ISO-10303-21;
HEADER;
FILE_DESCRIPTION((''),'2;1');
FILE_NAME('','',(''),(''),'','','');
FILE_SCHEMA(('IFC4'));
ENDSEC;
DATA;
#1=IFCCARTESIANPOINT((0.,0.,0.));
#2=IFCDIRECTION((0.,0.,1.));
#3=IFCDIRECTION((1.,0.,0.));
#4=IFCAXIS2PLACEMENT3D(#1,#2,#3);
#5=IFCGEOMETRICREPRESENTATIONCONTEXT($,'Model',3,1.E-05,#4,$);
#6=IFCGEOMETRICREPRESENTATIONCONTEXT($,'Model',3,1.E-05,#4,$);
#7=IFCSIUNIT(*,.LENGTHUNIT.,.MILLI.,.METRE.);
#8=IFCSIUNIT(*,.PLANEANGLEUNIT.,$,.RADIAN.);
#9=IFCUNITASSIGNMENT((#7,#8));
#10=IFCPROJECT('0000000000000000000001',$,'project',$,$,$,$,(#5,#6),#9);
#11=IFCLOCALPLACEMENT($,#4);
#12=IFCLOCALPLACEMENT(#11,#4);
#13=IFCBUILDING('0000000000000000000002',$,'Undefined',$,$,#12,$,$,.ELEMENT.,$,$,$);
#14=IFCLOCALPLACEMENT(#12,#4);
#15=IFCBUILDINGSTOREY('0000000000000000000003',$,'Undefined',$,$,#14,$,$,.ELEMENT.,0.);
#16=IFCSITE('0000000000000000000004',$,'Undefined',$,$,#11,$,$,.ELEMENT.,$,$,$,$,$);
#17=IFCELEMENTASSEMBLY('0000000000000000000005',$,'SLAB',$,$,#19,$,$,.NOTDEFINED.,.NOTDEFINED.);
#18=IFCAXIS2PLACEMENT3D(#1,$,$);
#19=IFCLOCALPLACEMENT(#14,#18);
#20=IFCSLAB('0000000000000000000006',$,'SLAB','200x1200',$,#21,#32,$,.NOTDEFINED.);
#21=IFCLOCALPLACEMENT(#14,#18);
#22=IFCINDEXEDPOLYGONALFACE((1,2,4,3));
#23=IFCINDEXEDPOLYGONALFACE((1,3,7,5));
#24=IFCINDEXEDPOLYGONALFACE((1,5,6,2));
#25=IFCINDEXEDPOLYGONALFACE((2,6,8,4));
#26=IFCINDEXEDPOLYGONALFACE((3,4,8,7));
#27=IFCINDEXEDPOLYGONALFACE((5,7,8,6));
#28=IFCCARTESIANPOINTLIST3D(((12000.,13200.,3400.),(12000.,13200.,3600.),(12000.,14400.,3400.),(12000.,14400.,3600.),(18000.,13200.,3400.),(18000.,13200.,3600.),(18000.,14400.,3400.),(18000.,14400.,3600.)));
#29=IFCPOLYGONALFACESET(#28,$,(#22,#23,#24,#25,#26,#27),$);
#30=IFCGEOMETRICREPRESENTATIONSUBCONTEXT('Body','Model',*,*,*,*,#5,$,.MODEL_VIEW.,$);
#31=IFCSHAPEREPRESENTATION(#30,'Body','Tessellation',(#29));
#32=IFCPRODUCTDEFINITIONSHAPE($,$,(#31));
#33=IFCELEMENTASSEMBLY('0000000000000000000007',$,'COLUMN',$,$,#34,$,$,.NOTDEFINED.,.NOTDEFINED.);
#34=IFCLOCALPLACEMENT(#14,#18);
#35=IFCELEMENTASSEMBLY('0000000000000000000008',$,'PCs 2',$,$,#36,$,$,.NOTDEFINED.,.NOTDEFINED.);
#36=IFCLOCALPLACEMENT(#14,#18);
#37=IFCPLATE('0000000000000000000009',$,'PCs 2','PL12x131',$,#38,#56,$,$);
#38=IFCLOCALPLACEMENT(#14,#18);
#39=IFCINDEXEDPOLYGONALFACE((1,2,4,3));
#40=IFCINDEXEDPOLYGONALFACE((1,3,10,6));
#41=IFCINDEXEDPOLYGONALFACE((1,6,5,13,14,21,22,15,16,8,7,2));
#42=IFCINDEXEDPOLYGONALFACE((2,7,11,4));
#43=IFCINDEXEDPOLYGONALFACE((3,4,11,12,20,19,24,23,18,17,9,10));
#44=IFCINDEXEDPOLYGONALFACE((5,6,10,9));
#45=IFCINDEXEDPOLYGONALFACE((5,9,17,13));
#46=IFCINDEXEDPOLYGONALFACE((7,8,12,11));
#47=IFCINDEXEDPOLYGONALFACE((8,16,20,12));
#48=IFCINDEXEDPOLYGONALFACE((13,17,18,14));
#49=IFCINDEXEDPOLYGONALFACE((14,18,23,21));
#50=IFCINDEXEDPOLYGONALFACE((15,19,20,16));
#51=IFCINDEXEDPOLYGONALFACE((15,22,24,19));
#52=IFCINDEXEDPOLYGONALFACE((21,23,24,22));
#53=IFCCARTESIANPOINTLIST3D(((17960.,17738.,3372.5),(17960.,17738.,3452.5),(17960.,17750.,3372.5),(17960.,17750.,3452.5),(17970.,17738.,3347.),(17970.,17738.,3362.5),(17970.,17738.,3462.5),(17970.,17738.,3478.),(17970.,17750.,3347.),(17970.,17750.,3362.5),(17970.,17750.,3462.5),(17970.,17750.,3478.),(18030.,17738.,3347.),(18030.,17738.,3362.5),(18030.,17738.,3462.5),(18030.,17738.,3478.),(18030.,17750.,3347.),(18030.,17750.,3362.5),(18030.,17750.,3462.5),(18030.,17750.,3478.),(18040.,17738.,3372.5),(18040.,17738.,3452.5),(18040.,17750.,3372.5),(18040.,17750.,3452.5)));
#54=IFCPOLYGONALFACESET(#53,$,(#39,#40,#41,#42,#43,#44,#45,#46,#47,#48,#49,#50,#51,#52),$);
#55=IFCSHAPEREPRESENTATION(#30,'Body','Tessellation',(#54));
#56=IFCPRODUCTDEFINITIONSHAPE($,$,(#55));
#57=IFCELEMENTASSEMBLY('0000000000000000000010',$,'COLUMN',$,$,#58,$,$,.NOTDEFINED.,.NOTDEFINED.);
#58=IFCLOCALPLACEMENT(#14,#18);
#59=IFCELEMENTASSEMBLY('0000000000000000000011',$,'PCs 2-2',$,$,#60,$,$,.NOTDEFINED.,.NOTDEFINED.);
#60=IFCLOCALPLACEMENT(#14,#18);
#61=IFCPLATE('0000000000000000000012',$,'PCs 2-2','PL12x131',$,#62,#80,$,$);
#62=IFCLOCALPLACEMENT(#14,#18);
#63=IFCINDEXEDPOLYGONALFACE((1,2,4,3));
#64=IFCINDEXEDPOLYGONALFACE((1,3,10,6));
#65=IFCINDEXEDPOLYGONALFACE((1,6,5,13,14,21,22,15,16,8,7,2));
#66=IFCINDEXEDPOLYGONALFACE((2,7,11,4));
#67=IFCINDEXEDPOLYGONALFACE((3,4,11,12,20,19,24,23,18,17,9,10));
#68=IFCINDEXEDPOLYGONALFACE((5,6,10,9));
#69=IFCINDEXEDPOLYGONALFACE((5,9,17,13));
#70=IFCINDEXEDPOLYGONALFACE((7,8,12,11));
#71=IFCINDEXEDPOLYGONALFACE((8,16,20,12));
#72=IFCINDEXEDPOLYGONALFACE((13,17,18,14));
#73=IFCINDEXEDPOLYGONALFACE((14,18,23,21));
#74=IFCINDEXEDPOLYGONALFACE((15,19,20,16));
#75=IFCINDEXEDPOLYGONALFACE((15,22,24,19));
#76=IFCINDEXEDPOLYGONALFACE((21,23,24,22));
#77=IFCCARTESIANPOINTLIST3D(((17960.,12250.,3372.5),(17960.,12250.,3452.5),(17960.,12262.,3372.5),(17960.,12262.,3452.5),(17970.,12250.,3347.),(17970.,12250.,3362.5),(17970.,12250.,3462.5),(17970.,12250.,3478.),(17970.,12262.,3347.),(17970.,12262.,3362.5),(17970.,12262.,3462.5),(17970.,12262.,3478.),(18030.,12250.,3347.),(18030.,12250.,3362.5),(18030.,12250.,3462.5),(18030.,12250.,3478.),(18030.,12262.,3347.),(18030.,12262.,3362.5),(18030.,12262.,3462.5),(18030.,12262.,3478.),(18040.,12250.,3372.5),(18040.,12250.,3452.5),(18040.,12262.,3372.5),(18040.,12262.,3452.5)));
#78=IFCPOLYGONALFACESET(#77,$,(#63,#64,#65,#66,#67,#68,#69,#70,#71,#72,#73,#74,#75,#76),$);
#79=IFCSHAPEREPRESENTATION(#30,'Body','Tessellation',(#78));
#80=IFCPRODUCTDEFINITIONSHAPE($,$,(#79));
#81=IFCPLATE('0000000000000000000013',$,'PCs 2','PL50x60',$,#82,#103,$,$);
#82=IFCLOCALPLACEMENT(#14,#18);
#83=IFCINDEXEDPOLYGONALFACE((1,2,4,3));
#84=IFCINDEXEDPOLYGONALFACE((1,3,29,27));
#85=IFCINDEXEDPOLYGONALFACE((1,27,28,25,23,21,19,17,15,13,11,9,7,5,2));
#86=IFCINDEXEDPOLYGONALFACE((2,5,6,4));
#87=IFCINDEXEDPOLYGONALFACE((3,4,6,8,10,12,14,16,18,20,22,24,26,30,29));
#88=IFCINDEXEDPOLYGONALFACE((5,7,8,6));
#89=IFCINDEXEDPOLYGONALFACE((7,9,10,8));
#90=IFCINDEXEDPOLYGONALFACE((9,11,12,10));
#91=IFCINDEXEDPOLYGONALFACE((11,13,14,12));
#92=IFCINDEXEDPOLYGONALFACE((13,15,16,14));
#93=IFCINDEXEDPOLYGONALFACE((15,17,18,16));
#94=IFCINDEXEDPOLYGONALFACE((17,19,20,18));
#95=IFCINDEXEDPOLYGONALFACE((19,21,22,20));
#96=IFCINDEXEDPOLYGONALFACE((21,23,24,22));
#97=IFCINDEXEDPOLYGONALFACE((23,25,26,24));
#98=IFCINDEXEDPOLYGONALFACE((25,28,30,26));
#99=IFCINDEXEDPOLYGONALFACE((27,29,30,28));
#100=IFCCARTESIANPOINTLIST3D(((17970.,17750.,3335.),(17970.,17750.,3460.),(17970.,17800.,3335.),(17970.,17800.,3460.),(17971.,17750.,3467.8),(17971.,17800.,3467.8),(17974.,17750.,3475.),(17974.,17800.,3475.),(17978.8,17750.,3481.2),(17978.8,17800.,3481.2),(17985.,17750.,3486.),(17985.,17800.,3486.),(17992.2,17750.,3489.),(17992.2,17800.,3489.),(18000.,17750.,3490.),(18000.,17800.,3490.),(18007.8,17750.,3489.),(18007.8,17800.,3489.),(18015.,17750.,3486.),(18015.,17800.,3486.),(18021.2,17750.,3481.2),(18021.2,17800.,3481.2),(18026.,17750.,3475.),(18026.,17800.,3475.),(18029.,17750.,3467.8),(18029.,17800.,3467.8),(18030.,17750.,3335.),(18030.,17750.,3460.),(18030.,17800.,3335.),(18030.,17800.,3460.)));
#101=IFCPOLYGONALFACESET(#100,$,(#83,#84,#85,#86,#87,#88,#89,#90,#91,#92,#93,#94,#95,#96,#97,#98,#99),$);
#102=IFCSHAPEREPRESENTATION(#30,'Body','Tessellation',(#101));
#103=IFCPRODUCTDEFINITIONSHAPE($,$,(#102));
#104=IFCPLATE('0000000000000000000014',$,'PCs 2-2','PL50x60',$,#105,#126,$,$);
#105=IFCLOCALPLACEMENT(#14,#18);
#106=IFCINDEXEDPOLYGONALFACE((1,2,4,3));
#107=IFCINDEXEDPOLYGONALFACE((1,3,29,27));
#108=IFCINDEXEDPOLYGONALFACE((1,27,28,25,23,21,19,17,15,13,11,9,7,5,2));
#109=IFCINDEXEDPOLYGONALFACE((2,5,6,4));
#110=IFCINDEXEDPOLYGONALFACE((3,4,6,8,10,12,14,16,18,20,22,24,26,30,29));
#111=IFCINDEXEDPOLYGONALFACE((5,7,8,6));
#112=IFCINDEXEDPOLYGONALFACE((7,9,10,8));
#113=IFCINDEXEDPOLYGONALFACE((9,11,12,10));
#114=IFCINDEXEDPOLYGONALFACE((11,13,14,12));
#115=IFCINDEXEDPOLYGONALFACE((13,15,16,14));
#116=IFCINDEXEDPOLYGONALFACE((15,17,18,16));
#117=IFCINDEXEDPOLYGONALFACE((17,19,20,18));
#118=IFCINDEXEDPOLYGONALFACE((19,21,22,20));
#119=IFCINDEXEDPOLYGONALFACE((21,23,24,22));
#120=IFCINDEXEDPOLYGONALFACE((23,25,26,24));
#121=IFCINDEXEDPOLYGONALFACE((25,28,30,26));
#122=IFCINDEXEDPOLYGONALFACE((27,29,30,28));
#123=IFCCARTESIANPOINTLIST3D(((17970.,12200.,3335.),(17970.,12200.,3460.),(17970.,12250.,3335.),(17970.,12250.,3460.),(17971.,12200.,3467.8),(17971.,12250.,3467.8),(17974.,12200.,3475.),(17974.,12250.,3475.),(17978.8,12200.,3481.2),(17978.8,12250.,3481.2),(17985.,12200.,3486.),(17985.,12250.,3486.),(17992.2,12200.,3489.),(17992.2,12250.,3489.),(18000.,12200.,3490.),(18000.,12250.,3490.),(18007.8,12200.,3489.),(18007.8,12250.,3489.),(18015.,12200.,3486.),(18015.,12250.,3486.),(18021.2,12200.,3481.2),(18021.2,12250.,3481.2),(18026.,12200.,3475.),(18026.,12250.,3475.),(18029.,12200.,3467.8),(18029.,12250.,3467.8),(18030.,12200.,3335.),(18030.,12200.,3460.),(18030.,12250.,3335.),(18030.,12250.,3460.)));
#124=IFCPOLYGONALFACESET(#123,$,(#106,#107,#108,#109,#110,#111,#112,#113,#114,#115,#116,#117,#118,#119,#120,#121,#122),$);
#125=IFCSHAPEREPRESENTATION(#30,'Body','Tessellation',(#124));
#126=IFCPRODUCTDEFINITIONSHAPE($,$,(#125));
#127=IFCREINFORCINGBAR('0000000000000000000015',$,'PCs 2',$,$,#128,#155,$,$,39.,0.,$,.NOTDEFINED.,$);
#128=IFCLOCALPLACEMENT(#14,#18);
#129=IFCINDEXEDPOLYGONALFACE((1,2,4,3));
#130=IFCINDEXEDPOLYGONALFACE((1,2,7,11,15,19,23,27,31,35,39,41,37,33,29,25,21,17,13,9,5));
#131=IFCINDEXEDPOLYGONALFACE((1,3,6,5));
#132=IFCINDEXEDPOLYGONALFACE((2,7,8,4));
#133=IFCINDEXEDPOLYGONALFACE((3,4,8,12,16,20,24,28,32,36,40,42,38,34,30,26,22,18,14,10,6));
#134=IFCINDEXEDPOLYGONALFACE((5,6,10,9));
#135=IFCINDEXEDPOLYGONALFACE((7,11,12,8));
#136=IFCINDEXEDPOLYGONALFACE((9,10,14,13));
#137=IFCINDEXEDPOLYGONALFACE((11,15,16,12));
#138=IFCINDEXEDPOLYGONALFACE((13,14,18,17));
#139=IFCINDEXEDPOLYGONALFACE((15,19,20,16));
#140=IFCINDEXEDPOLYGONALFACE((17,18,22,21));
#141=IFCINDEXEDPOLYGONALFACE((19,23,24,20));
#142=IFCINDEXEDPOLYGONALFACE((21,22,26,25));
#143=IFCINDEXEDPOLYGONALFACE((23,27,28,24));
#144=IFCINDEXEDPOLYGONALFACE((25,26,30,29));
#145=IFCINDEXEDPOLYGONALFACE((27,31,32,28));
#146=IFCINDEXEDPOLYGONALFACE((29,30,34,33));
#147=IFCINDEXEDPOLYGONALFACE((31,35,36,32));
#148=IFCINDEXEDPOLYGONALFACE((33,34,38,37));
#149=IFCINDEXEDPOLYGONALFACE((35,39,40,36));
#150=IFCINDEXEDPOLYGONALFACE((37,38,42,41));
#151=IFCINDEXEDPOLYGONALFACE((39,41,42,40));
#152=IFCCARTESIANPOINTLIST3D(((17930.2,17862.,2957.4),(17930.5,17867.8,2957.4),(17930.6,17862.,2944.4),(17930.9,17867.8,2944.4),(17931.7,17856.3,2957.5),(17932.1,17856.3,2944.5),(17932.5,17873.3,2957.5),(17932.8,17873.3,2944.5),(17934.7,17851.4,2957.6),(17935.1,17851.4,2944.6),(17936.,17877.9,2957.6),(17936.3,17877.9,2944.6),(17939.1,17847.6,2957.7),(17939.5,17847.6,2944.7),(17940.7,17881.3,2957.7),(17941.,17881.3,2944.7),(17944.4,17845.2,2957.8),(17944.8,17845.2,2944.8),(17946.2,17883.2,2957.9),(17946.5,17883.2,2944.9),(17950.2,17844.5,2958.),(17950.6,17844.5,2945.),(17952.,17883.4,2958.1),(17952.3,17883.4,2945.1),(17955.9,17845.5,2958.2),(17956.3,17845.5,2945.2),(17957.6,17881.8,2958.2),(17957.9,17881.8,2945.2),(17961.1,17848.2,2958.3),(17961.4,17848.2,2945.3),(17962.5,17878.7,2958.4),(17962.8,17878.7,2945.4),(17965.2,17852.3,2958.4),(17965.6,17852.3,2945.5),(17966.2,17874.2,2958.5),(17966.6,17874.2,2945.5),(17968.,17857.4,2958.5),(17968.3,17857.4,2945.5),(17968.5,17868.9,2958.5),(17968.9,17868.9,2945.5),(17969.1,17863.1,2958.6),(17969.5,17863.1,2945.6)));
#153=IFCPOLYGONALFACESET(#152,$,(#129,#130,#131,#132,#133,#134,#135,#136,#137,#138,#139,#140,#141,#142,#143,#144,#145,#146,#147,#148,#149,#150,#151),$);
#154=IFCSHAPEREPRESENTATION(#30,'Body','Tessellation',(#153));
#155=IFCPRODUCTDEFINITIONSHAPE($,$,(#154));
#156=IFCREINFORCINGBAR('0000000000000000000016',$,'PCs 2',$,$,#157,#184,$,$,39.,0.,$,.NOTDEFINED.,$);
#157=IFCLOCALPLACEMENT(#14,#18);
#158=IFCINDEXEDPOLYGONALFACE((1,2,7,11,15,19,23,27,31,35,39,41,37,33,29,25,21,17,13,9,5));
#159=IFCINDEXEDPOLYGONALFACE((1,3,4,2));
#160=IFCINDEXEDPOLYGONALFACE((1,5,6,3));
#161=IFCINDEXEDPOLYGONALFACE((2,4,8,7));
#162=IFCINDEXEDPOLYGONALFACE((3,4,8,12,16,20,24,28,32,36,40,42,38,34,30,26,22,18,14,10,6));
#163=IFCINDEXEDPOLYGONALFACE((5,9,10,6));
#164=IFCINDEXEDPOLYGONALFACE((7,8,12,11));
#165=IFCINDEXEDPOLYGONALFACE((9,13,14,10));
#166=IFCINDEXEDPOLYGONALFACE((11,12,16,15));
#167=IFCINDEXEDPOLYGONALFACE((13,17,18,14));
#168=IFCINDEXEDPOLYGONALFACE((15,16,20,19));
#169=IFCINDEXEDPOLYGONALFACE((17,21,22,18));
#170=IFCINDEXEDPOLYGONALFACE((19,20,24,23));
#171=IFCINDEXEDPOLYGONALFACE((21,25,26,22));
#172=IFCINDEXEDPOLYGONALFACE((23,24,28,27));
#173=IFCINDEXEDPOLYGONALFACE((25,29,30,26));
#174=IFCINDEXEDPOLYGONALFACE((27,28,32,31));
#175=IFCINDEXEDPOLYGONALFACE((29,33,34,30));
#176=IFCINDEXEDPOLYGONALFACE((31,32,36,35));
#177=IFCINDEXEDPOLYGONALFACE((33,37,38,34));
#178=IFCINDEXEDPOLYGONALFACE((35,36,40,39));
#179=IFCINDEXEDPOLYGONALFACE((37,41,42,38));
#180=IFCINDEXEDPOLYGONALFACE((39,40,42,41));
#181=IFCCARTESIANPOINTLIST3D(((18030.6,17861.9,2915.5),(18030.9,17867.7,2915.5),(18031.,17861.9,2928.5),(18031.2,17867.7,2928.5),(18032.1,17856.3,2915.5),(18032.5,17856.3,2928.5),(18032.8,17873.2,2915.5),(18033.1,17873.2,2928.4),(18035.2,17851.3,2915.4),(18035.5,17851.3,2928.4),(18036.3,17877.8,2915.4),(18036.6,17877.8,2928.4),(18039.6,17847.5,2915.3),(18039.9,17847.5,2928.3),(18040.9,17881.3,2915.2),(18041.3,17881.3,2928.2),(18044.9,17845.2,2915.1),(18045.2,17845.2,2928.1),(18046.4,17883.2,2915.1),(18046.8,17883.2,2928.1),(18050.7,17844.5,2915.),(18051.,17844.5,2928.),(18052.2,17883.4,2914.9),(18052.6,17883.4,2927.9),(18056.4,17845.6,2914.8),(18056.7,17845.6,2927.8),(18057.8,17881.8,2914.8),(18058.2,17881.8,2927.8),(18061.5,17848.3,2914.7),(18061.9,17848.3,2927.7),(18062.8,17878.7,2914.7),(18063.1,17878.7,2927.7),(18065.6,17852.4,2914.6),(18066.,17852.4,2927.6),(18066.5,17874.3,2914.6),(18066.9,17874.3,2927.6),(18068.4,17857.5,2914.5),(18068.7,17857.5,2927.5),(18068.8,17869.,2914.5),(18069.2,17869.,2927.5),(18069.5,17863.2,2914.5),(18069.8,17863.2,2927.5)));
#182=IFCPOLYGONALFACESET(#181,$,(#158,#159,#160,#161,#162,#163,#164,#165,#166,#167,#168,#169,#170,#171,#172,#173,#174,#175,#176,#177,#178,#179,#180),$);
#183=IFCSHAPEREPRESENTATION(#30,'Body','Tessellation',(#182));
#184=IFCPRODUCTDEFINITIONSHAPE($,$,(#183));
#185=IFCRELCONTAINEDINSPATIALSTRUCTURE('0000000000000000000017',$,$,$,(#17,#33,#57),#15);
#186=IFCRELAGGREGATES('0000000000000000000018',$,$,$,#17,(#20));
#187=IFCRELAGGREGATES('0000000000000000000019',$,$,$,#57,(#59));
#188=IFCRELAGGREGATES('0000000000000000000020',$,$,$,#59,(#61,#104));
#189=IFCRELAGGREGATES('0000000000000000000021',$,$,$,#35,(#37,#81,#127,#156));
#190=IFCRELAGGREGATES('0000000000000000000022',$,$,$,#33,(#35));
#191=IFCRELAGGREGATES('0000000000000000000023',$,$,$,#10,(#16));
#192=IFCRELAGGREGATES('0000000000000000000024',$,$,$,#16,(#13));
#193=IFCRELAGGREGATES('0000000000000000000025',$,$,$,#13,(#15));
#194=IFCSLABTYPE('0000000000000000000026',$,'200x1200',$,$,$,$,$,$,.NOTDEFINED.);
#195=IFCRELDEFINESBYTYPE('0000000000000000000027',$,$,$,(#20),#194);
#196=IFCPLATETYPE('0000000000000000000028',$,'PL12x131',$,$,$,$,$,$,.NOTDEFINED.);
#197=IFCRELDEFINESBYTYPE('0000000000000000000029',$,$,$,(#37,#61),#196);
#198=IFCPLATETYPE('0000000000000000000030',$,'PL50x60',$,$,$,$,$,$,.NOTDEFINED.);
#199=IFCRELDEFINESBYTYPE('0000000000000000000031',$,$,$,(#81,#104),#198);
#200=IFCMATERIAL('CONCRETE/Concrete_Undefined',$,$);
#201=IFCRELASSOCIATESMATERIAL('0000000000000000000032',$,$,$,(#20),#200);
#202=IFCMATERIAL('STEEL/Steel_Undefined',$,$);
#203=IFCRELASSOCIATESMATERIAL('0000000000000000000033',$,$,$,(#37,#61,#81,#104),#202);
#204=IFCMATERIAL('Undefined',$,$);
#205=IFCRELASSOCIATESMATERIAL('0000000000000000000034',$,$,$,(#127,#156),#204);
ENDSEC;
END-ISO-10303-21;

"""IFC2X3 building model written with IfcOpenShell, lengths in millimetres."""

from ifc_helpers import new_model, entity, si_unit, frame, frame_2d, origin_with_axes, place, context, subcontext, project, spatial, polyline, circle_curve, parameter, trimmed, segment, composite_curve, outline, extrude, source, transform, mapped, material, type_object, element, aggregate, save


model = new_model("IFC2X3")

# Units and contexts
model_context_1 = context("Model", 3, precision=1e-05, world=origin_with_axes())
model_context_2 = context("Model", 3, precision=1e-05, world=origin_with_axes())
body_context = subcontext(model_context_1, "Body", "Model", "MODEL_VIEW")
ifc_project = project(units=[si_unit("LENGTHUNIT", "METRE", prefix="MILLI"), si_unit("PLANEANGLEUNIT", "RADIAN")], contexts=[model_context_1, model_context_2])

# Site, building, storey
site_placement = place(None, origin_with_axes())
site = spatial("IfcSite", under=ifc_project, at=site_placement, Name="Undefined", CompositionType="ELEMENT")
building_placement = place(site_placement, origin_with_axes())
building = spatial("IfcBuilding", under=site, at=building_placement, Name="Undefined", CompositionType="ELEMENT")
storey_placement = place(building_placement, origin_with_axes())
storey = spatial("IfcBuildingStorey", under=building, at=storey_placement, Name="Undefined", CompositionType="ELEMENT", Elevation=0.0)

# Shared definitions
ifc_material_1 = material(Name="STEEL/Steel_Undefined")

# Element assembly, slab
assembly_1_placement = place(storey_placement, origin_with_axes())
assembly_1 = element("IfcElementAssembly", 1, at=assembly_1_placement, inside=storey, Name="SLAB", AssemblyPlace="NOTDEFINED", PredefinedType="NOTDEFINED")
ifc_material_2 = material(Name="CONCRETE/Concrete_Undefined")
slab_type = type_object("IfcSlabType", Name="200x1200", PredefinedType="NOTDEFINED")
slab_placement = place(assembly_1_placement, frame((18000.0, 13200.0, 3500.0), z_axis=(0.0, 0.0, 1.0), x_axis=(0.0, 1.0, 0.0)))
slab = element("IfcSlab", 2, at=slab_placement, type_object=slab_type, material=ifc_material_2, Name="SLAB", Description="200x1200", PredefinedType="NOTDEFINED", context=body_context, shape_type="SweptSolid", body=[
    extrude(outline(polyline([(0.0, 0.0), (1200.0, 0.0), (1200.0, 6000.0), (0.0, 6000.0), (0.0, 0.0)])), frame((0.0, 0.0, -100.0), z_axis=(0.0, 0.0, 1.0), x_axis=(1.0, 0.0, 0.0)), (0.0, 0.0, 1.0), 200.0),
])
aggregate(assembly_1, [slab])

# Element assemblies, plates
assembly_2_placement = place(storey_placement, origin_with_axes())
assembly_2 = element("IfcElementAssembly", 3, at=assembly_2_placement, inside=storey, Name="COLUMN", AssemblyPlace="NOTDEFINED", PredefinedType="NOTDEFINED")
assembly_3_placement = place(assembly_2_placement, origin_with_axes())
assembly_3 = element("IfcElementAssembly", 4, at=assembly_3_placement, Name="PCs 2", AssemblyPlace="NOTDEFINED", PredefinedType="NOTDEFINED")
plate_type_1 = type_object("IfcPlateType", Name="PL12x131", PredefinedType="NOTDEFINED")
plate_1_placement = place(assembly_3_placement, frame((17970.0, 17744.0, 3478.0), z_axis=(0.0, -1.0, 0.0), x_axis=(0.0, 0.0, -1.0)))
plate_1 = element("IfcPlate", 5, at=plate_1_placement, type_object=plate_type_1, material=ifc_material_1, Name="PCs 2", Description="PL12x131", context=body_context, shape_type="SweptSolid", body=[
    extrude(outline(polyline([(0.0, 0.0), (15.5, 0.0), (25.5, -10.0), (105.5, -10.0), (115.5, 0.0), (131.0, 0.0), (131.0, 60.0), (115.5, 60.0), (105.5, 70.0), (25.5, 70.0), (15.5, 60.0), (0.0, 60.0), (0.0, 0.0)])), frame((0.0, 0.0, -6.0), z_axis=(0.0, 0.0, 1.0), x_axis=(1.0, 0.0, 0.0)), (0.0, 0.0, 1.0), 12.0),
])
assembly_4_placement = place(storey_placement, origin_with_axes())
assembly_4 = element("IfcElementAssembly", 6, at=assembly_4_placement, inside=storey, Name="COLUMN", AssemblyPlace="NOTDEFINED", PredefinedType="NOTDEFINED")
assembly_5_placement = place(assembly_4_placement, origin_with_axes())
assembly_5 = element("IfcElementAssembly", 7, at=assembly_5_placement, Name="PCs 2-2", AssemblyPlace="NOTDEFINED", PredefinedType="NOTDEFINED")
aggregate(assembly_4, [assembly_5])
plate_2_placement = place(assembly_5_placement, frame((18030.0, 12256.0, 3478.0), z_axis=(0.0, 1.0, 0.0), x_axis=(0.0, 0.0, -1.0)))
plate_2 = element("IfcPlate", 8, at=plate_2_placement, type_object=plate_type_1, material=ifc_material_1, Name="PCs 2-2", Description="PL12x131", context=body_context, shape_type="SweptSolid", body=[
    extrude(outline(polyline([(0.0, 0.0), (15.5, 0.0), (25.5, -10.0), (105.5, -10.0), (115.5, 0.0), (131.0, 0.0), (131.0, 60.0), (115.5, 60.0), (105.5, 70.0), (25.5, 70.0), (15.5, 60.0), (0.0, 60.0), (0.0, 0.0)])), frame((0.0, 0.0, -6.0), z_axis=(0.0, 0.0, 1.0), x_axis=(1.0, 0.0, 0.0)), (0.0, 0.0, 1.0), 12.0),
])

# Plates
plate_type_2 = type_object("IfcPlateType", Name="PL50x60", PredefinedType="NOTDEFINED")
plate_3_placement = place(assembly_3_placement, frame((17970.0, 17775.0, 3490.0), z_axis=(0.0, -1.0, 0.0), x_axis=(0.0, 0.0, -1.0)))
plate_3 = element("IfcPlate", 9, at=plate_3_placement, type_object=plate_type_2, material=ifc_material_1, Name="PCs 2", Description="PL50x60", context=body_context, shape_type="SweptSolid", body=[
    extrude(outline(composite_curve([segment(trimmed(circle_curve(frame_2d((30.0, 30.0), x_axis=(-1.0, 0.0)), 30.0), [parameter(0.0)], [parameter(1.570796)], True, "PARAMETER"), True, "CONTINUOUS"), segment(polyline([(30.0, 0.0), (155.0, 0.0), (155.0, 60.0), (30.0, 60.0)]), True, "CONTINUOUS"), segment(trimmed(circle_curve(frame_2d((30.0, 30.0), x_axis=(0.0, 1.0)), 30.0), [parameter(0.0)], [parameter(1.570796)], True, "PARAMETER"), True, "CONTINUOUS"), segment(polyline([(0.0, 30.0), (0.0, 30.0)]), True, "CONTINUOUS")], self_intersect=True)), frame((0.0, 0.0, -25.0), z_axis=(0.0, 0.0, 1.0), x_axis=(1.0, 0.0, 0.0)), (0.0, 0.0, 1.0), 50.0),
])
plate_4_placement = place(assembly_5_placement, frame((18030.0, 12225.0, 3490.0), z_axis=(0.0, 1.0, 0.0), x_axis=(0.0, 0.0, -1.0)))
plate_4 = element("IfcPlate", 10, at=plate_4_placement, type_object=plate_type_2, material=ifc_material_1, Name="PCs 2-2", Description="PL50x60", context=body_context, shape_type="SweptSolid", body=[
    extrude(outline(composite_curve([segment(trimmed(circle_curve(frame_2d((30.0, 30.0), x_axis=(-1.0, 0.0)), 30.0), [parameter(0.0)], [parameter(1.570796)], True, "PARAMETER"), True, "CONTINUOUS"), segment(polyline([(30.0, 0.0), (155.0, 0.0), (155.0, 60.0), (30.0, 60.0)]), True, "CONTINUOUS"), segment(trimmed(circle_curve(frame_2d((30.0, 30.0), x_axis=(0.0, 1.0)), 30.0), [parameter(0.0)], [parameter(1.570796)], True, "PARAMETER"), True, "CONTINUOUS"), segment(polyline([(0.0, 30.0), (0.0, 30.0)]), True, "CONTINUOUS")], self_intersect=True)), frame((0.0, 0.0, -25.0), z_axis=(0.0, 0.0, 1.0), x_axis=(1.0, 0.0, 0.0)), (0.0, 0.0, 1.0), 50.0),
])
aggregate(assembly_5, [plate_2, plate_4])

# Reinforcing bars
ifc_material_3 = material(Name="Undefined")
shared_shape_1 = source(origin_with_axes(), body_context, "Body", "AdvancedSweptSolid", [
    entity("IfcSweptDiskSolid", entity("IfcTrimmedCurve", entity("IfcLine", entity("IfcCartesianPoint", [0.0, 0.0, 0.0]), entity("IfcVector", entity("IfcDirection", [1.0, 0.0, 0.0]), 1.0)), [entity("IfcParameterValue", 0.0)], [entity("IfcParameterValue", 13.0)], True, "PARAMETER"), 19.5, None, 0.0, 13.0),
])
reinforcing_bar_1_placement = place(assembly_3_placement, frame((17949.6, 17864.0, 2958.0), z_axis=(-0.701084, 0.712786, -0.020417), x_axis=(0.02911, 0.0, -0.999576)))
reinforcing_bar_1 = element("IfcReinforcingBar", 11, at=reinforcing_bar_1_placement, material=ifc_material_3, Name="PCs 2", BarRole="NOTDEFINED", CrossSectionArea=0.0, NominalDiameter=39.0, context=body_context, shape_type="MappedRepresentation", body=[
    mapped(shared_shape_1, transform((0.0, 0.0, 0.0))),
])
shared_shape_2 = source(origin_with_axes(), body_context, "Body", "AdvancedSweptSolid", [
    entity("IfcSweptDiskSolid", entity("IfcTrimmedCurve", entity("IfcLine", entity("IfcCartesianPoint", [0.0, 0.0, 0.0]), entity("IfcVector", entity("IfcDirection", [1.0, 0.0, 0.0]), 1.0)), [entity("IfcParameterValue", 0.0)], [entity("IfcParameterValue", 13.0)], True, "PARAMETER"), 19.5, None, 0.0, 13.0),
])
reinforcing_bar_2_placement = place(assembly_3_placement, frame((18050.3, 17864.0, 2928.0), z_axis=(-0.704756, 0.709208, 0.018503), x_axis=(-0.026246, 0.0, -0.999656)))
reinforcing_bar_2 = element("IfcReinforcingBar", 12, at=reinforcing_bar_2_placement, material=ifc_material_3, Name="PCs 2", BarRole="NOTDEFINED", CrossSectionArea=0.0, NominalDiameter=39.0, context=body_context, shape_type="MappedRepresentation", body=[
    mapped(shared_shape_2, transform((0.0, 0.0, 0.0))),
])
aggregate(assembly_3, [plate_1, plate_3, reinforcing_bar_1, reinforcing_bar_2])

aggregate(assembly_2, [assembly_3])

save(model, "model.ifc")
